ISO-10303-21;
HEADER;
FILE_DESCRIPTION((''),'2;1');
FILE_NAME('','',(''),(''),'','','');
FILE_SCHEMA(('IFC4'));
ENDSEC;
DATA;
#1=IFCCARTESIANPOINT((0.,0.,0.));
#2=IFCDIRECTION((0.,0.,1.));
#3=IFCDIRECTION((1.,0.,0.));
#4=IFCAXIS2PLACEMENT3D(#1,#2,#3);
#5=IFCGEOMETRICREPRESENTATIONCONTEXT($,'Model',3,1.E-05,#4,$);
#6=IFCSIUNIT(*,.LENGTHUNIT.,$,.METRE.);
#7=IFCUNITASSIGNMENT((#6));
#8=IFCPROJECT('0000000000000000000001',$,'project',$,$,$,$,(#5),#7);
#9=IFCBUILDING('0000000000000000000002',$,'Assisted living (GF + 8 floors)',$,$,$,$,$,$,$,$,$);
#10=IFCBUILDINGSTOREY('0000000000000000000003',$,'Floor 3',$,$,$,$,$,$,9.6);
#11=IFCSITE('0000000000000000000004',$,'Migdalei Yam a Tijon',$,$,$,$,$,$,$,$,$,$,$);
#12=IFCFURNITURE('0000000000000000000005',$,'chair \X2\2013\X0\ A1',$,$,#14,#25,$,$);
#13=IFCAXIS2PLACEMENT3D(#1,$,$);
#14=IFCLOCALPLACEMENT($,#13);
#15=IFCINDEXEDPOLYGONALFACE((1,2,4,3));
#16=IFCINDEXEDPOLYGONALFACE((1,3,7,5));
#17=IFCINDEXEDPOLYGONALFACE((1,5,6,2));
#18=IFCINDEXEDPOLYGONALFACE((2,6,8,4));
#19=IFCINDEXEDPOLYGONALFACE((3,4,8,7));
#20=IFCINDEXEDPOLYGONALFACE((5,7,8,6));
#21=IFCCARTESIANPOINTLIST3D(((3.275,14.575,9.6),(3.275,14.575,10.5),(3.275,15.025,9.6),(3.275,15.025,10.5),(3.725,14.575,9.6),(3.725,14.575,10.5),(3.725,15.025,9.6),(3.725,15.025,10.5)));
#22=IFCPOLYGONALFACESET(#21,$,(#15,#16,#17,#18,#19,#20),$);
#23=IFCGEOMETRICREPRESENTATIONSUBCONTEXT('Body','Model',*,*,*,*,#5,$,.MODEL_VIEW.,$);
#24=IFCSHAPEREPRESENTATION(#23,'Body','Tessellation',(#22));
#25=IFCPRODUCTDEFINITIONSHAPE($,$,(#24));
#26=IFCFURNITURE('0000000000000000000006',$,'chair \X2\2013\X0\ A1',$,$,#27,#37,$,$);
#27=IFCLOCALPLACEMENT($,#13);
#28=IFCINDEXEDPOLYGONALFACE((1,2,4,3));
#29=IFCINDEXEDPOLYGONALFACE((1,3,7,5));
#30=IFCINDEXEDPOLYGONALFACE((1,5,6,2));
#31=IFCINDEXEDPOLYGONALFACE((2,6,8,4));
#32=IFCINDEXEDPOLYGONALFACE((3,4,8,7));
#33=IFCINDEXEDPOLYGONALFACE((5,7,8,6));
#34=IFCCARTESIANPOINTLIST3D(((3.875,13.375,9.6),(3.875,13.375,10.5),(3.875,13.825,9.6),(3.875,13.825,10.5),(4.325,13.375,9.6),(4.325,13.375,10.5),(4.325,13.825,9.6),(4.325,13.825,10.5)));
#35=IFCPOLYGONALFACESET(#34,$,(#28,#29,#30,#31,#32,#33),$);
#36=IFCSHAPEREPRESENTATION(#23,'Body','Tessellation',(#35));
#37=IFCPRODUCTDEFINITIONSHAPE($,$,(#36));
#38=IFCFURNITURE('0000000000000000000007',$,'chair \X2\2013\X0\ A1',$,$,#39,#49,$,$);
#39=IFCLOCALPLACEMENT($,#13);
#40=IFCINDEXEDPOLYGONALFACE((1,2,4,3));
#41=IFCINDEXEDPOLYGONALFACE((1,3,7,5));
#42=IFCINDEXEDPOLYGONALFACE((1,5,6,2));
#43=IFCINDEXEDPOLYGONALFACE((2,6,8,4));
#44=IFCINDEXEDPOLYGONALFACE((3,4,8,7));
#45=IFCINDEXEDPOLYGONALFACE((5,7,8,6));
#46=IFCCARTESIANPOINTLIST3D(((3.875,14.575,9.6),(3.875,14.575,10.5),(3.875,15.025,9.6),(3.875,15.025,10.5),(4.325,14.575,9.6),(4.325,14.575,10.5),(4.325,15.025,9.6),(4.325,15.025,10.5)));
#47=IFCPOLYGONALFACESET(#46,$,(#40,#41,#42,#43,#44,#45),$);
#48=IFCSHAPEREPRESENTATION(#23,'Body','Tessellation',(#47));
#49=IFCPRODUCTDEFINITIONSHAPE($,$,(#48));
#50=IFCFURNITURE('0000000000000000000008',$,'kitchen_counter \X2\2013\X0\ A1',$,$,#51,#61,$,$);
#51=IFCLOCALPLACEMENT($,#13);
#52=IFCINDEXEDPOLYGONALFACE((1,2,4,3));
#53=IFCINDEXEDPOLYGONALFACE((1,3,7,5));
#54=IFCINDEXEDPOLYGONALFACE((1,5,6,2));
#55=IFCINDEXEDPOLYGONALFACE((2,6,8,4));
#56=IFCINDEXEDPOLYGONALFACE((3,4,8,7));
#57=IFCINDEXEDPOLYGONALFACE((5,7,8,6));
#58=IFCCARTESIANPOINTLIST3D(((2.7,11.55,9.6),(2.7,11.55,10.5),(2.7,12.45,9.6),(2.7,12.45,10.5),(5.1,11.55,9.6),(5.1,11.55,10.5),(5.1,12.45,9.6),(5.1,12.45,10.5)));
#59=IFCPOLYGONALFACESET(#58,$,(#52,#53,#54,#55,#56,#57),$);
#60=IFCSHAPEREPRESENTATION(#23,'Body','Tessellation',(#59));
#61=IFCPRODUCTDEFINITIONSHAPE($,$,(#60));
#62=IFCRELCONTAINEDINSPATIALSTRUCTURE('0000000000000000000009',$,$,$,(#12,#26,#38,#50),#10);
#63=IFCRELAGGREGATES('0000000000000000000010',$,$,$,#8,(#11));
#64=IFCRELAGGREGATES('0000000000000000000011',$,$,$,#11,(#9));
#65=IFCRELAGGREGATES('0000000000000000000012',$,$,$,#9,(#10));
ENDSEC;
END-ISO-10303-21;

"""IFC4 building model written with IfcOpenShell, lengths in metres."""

from ifc_helpers import new_model, si_unit, frame, origin_with_axes, context, subcontext, project, spatial, line, indexed_curve, outline, extrude, element, save


model = new_model("IFC4")

# Units and contexts
model_context = context("Model", 3, precision=1e-05, world=origin_with_axes())
body_context = subcontext(model_context, "Body", "Model", "MODEL_VIEW")
ifc_project = project(units=[si_unit("LENGTHUNIT", "METRE")], contexts=[model_context])

# Site, building, storey
site = spatial("IfcSite", under=ifc_project, Name="Migdalei Yam a Tijon")
building = spatial("IfcBuilding", under=site, Name="Assisted living (GF + 8 floors)")
storey = spatial("IfcBuildingStorey", under=building, Name="Floor 3", Elevation=9.6)

# Furniture
element("IfcFurniture", 1, inside=storey, Name="chair – A1", context=body_context, shape_type="SweptSolid", body=[
    extrude(outline(indexed_curve([(0.0, 0.0), (0.45, 0.0), (0.45, 0.45), (0.0, 0.45)], segments=[line(1, 2, 3, 4, 1)])), frame((3.275, 14.575, 9.6), z_axis=(0.0, 0.0, 1.0), x_axis=(1.0, 0.0, 0.0)), (0.0, 0.0, 1.0), 0.9),
])
element("IfcFurniture", 2, inside=storey, Name="chair – A1", context=body_context, shape_type="SweptSolid", body=[
    extrude(outline(indexed_curve([(0.0, 0.0), (0.45, 0.0), (0.45, 0.45), (0.0, 0.45)], segments=[line(1, 2, 3, 4, 1)])), frame((3.875, 13.375, 9.6), z_axis=(0.0, 0.0, 1.0), x_axis=(1.0, 0.0, 0.0)), (0.0, 0.0, 1.0), 0.9),
])
element("IfcFurniture", 3, inside=storey, Name="chair – A1", context=body_context, shape_type="SweptSolid", body=[
    extrude(outline(indexed_curve([(0.0, 0.0), (0.45, 0.0), (0.45, 0.45), (0.0, 0.45)], segments=[line(1, 2, 3, 4, 1)])), frame((3.875, 14.575, 9.6), z_axis=(0.0, 0.0, 1.0), x_axis=(1.0, 0.0, 0.0)), (0.0, 0.0, 1.0), 0.9),
])
element("IfcFurniture", 4, inside=storey, Name="kitchen_counter – A1", context=body_context, shape_type="SweptSolid", body=[
    extrude(outline(indexed_curve([(0.0, 0.0), (2.4, 0.0), (2.4, 0.9), (0.0, 0.9)], segments=[line(1, 2, 3, 4, 1)])), frame((2.7, 11.55, 9.6), z_axis=(0.0, 0.0, 1.0), x_axis=(1.0, 0.0, 0.0)), (0.0, 0.0, 1.0), 0.9),
])

save(model, "model.ifc")
